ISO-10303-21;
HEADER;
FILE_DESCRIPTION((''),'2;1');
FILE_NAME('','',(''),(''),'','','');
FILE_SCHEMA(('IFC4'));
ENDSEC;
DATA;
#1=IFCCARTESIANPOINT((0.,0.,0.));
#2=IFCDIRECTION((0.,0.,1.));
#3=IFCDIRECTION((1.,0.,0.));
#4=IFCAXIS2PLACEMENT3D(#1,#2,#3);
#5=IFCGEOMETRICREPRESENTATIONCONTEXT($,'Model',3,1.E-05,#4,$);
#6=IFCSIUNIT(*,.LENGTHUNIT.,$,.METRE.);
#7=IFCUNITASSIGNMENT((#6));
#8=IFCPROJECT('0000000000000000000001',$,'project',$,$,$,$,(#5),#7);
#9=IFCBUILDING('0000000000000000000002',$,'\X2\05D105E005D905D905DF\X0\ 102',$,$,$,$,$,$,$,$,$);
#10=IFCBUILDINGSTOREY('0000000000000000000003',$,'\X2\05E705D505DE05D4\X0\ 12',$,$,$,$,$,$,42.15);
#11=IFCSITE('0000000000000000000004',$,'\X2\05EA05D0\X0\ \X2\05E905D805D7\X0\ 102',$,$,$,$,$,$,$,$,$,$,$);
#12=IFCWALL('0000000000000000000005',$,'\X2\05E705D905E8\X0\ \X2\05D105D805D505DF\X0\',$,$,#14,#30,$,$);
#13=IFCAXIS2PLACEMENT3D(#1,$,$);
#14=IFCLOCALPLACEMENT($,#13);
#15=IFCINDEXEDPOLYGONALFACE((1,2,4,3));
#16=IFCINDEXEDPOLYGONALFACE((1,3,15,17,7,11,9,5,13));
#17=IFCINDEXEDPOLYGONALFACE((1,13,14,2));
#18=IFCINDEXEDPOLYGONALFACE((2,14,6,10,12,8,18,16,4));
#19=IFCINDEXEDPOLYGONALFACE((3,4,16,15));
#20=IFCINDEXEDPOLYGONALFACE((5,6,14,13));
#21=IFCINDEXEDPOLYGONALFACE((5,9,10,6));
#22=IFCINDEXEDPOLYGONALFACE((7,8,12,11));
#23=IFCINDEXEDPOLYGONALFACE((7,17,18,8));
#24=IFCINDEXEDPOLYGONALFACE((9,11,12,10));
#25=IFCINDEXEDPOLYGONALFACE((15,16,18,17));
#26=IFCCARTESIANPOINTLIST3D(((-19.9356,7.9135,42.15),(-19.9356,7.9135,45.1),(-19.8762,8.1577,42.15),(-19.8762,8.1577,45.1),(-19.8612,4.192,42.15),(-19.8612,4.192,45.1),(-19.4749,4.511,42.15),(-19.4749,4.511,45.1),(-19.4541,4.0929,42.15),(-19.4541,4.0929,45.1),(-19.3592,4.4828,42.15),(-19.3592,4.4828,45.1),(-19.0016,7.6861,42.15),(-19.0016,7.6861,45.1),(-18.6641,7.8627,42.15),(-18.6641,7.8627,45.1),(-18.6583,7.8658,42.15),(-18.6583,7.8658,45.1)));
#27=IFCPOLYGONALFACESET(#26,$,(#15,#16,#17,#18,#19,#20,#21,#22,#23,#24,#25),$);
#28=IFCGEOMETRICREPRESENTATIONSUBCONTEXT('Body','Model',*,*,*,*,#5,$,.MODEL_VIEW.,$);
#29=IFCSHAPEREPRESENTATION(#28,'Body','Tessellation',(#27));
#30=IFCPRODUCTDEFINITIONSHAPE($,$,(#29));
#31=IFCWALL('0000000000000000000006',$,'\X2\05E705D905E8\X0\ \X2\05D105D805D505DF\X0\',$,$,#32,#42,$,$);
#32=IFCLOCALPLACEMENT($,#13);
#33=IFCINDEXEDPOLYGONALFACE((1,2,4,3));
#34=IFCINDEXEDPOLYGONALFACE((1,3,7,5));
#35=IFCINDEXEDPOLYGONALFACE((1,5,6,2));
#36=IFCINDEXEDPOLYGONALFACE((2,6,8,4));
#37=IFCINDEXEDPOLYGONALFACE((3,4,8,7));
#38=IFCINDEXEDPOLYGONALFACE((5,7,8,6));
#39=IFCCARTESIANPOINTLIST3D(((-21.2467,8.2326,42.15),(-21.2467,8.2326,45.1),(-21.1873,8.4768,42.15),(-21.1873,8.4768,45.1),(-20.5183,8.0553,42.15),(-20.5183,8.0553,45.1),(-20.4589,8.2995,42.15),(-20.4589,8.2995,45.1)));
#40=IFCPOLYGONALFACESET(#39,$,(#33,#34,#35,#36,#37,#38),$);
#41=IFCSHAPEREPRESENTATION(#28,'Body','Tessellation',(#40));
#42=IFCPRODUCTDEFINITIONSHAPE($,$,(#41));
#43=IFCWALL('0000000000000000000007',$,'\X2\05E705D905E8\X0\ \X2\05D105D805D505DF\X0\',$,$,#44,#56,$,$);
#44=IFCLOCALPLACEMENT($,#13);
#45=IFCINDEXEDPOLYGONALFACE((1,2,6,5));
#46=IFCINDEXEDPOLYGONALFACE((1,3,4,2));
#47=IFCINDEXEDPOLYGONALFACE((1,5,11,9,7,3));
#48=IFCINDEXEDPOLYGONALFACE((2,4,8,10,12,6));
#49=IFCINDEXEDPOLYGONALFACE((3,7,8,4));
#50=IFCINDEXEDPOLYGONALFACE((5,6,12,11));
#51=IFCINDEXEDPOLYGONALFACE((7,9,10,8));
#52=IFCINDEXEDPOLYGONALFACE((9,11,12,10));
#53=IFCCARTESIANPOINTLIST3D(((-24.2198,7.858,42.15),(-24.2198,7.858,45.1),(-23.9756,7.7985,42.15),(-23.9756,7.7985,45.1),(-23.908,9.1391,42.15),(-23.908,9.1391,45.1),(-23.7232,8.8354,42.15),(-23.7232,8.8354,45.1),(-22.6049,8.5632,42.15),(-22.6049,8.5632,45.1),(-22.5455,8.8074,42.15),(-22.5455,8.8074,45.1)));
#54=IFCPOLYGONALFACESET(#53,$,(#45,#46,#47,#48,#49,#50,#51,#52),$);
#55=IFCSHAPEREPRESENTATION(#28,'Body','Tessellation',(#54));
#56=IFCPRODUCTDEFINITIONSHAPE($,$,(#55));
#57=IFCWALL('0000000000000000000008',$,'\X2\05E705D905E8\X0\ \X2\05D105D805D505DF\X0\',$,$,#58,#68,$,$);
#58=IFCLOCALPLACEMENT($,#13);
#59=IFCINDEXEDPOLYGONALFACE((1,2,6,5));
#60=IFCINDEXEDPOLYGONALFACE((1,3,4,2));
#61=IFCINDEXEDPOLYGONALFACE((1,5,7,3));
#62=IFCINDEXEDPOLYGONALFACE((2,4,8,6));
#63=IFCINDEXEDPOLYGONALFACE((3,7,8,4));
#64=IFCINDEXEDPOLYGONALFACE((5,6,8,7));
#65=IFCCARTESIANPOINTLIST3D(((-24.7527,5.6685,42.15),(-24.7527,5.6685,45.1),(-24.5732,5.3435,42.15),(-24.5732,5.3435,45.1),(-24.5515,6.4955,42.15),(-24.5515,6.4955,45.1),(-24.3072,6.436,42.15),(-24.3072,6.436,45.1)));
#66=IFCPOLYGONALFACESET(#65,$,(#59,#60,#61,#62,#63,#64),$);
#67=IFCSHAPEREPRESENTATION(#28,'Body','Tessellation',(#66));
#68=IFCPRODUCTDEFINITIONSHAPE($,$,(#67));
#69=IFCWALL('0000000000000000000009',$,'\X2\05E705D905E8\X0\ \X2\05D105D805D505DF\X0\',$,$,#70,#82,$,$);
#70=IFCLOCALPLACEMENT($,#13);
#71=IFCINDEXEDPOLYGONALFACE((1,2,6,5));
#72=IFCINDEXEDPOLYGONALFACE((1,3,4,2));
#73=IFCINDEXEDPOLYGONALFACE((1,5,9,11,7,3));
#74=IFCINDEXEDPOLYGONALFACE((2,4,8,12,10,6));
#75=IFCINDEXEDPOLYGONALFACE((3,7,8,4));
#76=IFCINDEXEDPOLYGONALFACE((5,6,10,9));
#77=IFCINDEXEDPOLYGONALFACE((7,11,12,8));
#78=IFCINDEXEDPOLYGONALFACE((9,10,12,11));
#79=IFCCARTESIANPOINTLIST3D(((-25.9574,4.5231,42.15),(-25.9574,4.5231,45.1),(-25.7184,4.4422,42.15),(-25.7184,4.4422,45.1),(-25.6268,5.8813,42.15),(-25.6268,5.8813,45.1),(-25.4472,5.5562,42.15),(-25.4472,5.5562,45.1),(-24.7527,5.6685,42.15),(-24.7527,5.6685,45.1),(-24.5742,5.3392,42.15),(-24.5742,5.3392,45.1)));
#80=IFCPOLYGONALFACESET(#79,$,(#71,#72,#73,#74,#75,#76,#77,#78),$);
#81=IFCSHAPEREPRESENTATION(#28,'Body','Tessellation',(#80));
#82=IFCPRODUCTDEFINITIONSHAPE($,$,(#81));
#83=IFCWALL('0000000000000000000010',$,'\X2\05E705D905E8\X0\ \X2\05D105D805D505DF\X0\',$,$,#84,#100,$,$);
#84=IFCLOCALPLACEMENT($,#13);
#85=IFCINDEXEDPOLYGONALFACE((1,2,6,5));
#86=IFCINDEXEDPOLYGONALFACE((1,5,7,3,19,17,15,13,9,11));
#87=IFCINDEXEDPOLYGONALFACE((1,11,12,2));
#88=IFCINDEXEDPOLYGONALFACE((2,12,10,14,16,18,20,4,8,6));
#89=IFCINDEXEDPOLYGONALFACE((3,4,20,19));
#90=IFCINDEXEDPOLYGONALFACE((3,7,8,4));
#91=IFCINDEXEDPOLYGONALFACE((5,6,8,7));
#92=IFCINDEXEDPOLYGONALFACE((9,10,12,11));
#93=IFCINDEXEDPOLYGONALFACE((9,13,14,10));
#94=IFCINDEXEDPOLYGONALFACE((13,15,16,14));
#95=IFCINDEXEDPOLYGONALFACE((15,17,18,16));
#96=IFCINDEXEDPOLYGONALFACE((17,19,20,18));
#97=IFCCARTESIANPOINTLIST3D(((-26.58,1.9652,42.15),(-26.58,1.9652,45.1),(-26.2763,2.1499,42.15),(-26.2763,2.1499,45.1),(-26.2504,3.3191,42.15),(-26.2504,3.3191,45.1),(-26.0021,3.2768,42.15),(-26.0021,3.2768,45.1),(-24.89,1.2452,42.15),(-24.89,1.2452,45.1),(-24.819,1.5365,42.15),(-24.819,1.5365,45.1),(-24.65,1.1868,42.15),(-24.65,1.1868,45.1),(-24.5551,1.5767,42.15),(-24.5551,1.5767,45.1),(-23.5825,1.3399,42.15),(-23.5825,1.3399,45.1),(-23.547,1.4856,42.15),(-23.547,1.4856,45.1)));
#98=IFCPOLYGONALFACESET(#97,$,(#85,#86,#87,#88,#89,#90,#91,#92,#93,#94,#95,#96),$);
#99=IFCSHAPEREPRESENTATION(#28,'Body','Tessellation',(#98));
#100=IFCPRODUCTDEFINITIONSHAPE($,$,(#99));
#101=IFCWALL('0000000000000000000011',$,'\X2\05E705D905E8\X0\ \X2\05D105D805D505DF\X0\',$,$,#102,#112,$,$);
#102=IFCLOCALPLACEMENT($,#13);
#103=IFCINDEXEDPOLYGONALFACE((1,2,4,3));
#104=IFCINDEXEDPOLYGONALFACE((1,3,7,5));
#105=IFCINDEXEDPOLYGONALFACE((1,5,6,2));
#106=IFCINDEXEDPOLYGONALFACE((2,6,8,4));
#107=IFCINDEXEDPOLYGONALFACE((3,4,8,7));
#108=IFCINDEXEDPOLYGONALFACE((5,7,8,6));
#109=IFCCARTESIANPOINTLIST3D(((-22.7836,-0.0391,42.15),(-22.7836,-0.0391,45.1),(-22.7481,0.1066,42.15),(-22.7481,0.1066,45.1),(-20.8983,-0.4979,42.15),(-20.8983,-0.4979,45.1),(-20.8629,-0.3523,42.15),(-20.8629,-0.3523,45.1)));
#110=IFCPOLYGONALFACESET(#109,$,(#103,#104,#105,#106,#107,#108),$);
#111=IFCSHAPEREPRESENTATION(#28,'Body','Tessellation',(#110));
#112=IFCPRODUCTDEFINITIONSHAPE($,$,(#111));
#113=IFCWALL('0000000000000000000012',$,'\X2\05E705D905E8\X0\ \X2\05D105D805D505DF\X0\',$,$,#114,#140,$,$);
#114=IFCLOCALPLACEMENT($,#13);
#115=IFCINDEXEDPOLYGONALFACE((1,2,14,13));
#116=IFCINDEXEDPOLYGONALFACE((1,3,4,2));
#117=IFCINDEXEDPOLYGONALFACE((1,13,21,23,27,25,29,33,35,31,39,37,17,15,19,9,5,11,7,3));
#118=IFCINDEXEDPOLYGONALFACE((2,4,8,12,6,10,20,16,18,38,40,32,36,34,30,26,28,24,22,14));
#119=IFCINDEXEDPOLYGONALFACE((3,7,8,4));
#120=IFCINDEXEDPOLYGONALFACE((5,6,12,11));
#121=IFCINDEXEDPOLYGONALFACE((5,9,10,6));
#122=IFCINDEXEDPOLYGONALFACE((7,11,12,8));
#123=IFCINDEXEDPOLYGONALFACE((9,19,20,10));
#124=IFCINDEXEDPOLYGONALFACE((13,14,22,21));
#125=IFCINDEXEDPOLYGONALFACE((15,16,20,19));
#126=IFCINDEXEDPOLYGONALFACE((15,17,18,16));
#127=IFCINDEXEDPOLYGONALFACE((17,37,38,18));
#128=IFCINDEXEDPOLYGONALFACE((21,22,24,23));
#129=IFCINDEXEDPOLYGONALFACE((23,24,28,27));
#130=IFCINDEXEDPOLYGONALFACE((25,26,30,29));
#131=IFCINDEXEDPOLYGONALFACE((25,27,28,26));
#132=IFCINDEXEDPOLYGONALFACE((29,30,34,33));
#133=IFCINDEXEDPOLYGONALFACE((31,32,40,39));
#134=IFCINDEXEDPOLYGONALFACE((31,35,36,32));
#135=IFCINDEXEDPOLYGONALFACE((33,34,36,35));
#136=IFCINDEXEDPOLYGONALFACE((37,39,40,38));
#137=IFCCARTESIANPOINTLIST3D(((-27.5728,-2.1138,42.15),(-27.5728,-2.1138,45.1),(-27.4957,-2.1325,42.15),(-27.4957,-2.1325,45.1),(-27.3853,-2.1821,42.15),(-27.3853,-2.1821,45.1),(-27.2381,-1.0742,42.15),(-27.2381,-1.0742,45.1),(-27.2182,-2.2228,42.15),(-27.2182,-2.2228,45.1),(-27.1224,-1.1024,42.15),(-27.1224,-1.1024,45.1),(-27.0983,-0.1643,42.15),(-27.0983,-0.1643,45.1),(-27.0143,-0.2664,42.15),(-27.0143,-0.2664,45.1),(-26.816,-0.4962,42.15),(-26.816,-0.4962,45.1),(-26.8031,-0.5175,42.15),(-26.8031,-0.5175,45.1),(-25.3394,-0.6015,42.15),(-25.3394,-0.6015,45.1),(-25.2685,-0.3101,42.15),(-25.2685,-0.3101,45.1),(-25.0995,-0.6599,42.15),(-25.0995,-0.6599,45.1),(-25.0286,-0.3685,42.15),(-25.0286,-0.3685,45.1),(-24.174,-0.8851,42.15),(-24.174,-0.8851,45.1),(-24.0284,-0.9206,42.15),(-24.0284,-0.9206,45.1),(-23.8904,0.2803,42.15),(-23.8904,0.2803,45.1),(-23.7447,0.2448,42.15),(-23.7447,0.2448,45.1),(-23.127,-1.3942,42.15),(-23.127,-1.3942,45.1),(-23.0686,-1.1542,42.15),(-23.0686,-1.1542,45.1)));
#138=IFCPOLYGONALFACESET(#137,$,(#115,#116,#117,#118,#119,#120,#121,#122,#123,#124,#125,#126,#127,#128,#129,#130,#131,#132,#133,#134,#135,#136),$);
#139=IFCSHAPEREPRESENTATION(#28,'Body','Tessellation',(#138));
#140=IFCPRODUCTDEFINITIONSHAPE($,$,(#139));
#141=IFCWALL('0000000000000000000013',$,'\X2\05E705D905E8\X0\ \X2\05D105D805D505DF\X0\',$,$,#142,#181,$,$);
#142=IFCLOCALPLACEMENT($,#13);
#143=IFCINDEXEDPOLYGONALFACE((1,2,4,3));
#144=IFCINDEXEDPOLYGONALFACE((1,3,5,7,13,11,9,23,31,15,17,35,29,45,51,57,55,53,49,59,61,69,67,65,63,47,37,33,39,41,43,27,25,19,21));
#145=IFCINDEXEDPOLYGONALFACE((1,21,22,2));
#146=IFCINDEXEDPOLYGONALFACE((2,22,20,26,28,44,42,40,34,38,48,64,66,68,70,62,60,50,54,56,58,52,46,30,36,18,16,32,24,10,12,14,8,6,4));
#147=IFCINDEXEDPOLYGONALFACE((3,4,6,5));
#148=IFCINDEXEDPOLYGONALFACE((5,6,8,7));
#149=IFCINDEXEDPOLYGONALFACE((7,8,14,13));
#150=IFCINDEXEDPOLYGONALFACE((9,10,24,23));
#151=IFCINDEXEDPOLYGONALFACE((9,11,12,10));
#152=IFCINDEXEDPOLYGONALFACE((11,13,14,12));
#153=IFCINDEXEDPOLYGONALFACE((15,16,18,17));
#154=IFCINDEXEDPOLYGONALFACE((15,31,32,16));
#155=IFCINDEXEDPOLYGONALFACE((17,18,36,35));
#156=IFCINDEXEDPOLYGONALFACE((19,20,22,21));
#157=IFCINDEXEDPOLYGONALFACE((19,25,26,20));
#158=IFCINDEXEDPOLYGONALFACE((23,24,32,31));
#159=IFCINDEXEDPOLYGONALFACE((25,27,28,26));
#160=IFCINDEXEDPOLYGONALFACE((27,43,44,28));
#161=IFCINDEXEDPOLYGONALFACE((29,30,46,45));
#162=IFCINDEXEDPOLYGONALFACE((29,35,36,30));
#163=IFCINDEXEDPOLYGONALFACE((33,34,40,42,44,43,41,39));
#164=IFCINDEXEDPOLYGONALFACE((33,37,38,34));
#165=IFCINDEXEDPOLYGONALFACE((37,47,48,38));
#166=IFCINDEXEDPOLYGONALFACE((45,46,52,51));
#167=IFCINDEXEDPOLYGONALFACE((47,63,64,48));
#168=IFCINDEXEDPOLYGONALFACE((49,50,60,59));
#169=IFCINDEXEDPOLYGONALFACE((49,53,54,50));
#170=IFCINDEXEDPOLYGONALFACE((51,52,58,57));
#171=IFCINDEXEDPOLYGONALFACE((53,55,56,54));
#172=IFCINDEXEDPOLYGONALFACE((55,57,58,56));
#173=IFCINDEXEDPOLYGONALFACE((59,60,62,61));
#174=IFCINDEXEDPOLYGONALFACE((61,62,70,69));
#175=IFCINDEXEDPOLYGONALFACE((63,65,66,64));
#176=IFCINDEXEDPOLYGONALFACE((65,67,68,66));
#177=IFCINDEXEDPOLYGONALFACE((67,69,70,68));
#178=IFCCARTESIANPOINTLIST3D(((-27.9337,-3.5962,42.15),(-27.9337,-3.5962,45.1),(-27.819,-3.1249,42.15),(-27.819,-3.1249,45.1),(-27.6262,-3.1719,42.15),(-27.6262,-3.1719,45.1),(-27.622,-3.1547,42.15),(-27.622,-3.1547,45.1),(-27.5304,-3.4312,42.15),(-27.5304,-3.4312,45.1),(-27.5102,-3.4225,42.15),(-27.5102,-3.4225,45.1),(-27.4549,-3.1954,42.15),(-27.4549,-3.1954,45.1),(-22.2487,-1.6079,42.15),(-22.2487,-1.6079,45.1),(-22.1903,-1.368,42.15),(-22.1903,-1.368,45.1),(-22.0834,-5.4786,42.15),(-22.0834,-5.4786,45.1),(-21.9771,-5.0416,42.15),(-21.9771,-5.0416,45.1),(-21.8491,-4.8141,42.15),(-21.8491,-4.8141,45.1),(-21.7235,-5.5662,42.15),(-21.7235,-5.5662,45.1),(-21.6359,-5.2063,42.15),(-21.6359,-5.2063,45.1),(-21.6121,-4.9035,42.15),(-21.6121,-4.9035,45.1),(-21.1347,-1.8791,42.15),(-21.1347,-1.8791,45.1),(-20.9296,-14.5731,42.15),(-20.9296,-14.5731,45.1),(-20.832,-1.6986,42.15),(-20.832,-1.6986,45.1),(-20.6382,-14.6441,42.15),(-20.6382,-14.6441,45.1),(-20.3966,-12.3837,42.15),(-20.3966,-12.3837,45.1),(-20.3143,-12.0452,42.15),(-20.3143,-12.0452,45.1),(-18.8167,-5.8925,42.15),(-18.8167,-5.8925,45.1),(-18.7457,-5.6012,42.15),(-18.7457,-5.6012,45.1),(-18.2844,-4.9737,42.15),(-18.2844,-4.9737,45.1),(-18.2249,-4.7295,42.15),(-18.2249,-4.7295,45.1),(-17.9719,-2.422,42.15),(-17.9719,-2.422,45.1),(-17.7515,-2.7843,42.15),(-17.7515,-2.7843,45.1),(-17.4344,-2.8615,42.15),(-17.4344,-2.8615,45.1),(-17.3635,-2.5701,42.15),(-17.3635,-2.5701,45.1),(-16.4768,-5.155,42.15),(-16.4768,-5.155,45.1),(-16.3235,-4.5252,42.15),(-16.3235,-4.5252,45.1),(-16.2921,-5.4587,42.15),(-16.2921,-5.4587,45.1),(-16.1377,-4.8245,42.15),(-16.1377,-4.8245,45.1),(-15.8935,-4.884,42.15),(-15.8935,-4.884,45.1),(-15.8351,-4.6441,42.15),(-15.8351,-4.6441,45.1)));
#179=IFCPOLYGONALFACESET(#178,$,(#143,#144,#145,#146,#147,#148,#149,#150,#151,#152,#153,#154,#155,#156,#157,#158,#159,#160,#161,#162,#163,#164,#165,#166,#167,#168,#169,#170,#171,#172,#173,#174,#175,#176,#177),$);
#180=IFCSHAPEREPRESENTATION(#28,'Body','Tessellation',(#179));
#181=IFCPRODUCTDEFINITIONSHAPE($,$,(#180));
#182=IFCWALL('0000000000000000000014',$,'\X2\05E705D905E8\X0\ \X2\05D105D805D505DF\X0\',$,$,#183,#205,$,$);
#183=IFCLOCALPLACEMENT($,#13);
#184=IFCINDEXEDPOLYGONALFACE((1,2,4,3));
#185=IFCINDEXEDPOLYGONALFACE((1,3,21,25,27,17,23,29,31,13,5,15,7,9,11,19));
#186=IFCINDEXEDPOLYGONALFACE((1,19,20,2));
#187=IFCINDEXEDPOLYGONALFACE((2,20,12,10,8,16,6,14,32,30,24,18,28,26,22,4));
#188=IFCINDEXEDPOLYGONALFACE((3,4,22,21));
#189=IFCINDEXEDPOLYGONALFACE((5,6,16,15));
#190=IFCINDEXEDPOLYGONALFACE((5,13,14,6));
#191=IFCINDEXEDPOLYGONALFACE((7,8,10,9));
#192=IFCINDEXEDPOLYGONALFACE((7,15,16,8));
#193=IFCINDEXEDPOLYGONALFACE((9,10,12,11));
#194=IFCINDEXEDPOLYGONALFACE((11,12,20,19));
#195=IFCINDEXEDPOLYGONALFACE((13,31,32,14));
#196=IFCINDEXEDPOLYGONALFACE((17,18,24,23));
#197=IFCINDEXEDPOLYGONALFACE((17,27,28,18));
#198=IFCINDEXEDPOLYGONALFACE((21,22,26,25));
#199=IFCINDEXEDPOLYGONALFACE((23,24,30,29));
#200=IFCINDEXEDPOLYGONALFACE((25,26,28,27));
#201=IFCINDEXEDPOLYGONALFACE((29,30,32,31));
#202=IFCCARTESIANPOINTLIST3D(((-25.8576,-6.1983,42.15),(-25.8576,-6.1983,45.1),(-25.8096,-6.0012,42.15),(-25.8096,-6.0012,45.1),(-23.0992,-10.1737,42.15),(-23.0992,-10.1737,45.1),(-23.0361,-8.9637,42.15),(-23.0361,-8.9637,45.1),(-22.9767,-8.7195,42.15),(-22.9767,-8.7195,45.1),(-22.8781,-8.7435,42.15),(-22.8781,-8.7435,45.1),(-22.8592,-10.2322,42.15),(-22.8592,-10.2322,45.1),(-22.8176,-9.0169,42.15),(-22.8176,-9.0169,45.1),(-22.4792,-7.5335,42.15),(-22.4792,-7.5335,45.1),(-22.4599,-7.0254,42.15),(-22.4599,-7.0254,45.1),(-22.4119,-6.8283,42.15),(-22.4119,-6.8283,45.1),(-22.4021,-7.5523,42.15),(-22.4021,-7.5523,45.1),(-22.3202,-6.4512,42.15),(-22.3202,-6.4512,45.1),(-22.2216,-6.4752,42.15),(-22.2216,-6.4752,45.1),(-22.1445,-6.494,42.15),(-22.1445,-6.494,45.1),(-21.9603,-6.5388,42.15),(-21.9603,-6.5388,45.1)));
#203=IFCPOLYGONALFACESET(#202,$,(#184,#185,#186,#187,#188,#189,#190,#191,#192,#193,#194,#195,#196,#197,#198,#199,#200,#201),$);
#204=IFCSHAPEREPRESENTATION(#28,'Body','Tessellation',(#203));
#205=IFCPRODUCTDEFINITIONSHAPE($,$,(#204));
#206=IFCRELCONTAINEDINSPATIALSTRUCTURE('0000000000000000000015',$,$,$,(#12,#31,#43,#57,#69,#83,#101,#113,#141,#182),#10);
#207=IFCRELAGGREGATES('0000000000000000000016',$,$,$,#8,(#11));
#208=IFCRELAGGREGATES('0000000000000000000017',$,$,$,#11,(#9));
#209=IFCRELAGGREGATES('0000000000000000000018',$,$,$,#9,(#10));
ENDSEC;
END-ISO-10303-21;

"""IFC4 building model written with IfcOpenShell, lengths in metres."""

from ifc_helpers import new_model, si_unit, frame, origin_with_axes, context, subcontext, project, spatial, polyline, outline, extrude, element, save


model = new_model("IFC4")

# Units and contexts
model_context = context("Model", 3, precision=1e-05, world=origin_with_axes())
body_context = subcontext(model_context, "Body", "Model", "MODEL_VIEW")
ifc_project = project(units=[si_unit("LENGTHUNIT", "METRE")], contexts=[model_context])

# Site, building, storey
site = spatial("IfcSite", under=ifc_project, Name="תא שטח 102")
building = spatial("IfcBuilding", under=site, Name="בניין 102")
storey = spatial("IfcBuildingStorey", under=building, Name="קומה 12", Elevation=42.15)

# Walls
element("IfcWall", 1, inside=storey, Name="קיר בטון", context=body_context, shape_type="SweptSolid", body=[
    extrude(outline(polyline([(-19.0016, 7.6861), (-19.8612, 4.192), (-19.4541, 4.0929), (-19.3592, 4.4828), (-19.4749, 4.511), (-18.6583, 7.8658), (-18.7159, 7.8344), (-18.6636, 7.8626), (-19.8762, 8.1577), (-19.9356, 7.9135), (-19.0016, 7.6861)])), frame((0.0, 0.0, 42.15)), (0.0, 0.0, 1.0), 2.95),
])
element("IfcWall", 2, inside=storey, Name="קיר בטון", context=body_context, shape_type="SweptSolid", body=[
    extrude(outline(polyline([(-20.4589, 8.2995), (-21.1873, 8.4768), (-21.2467, 8.2326), (-20.5183, 8.0553), (-20.4589, 8.2995)])), frame((0.0, 0.0, 42.15)), (0.0, 0.0, 1.0), 2.95),
])
element("IfcWall", 3, inside=storey, Name="קיר בטון", context=body_context, shape_type="SweptSolid", body=[
    extrude(outline(polyline([(-24.2198, 7.858), (-23.9756, 7.7985), (-23.7232, 8.8354), (-22.6049, 8.5632), (-22.5455, 8.8074), (-23.908, 9.1391), (-24.2198, 7.858)])), frame((0.0, 0.0, 42.15)), (0.0, 0.0, 1.0), 2.95),
])
element("IfcWall", 4, inside=storey, Name="קיר בטון", context=body_context, shape_type="SweptSolid", body=[
    extrude(outline(polyline([(-24.7527, 5.6685), (-24.5732, 5.3435), (-24.3072, 6.436), (-24.5515, 6.4955), (-24.7527, 5.6685)])), frame((0.0, 0.0, 42.15)), (0.0, 0.0, 1.0), 2.95),
])
element("IfcWall", 5, inside=storey, Name="קיר בטון", context=body_context, shape_type="SweptSolid", body=[
    extrude(outline(polyline([(-25.9574, 4.5231), (-25.7184, 4.4422), (-25.4472, 5.5562), (-24.5742, 5.3392), (-24.7527, 5.6685), (-25.6268, 5.8813), (-25.9574, 4.5231)])), frame((0.0, 0.0, 42.15)), (0.0, 0.0, 1.0), 2.95),
])
element("IfcWall", 6, inside=storey, Name="קיר בטון", context=body_context, shape_type="SweptSolid", body=[
    extrude(outline(polyline([(-26.58, 1.9652), (-24.819, 1.5365), (-24.89, 1.2452), (-24.65, 1.1868), (-24.5551, 1.5767), (-23.5825, 1.3399), (-23.547, 1.4856), (-26.2763, 2.1499), (-26.0021, 3.2768), (-26.2504, 3.3191), (-26.58, 1.9652)])), frame((0.0, 0.0, 42.15)), (0.0, 0.0, 1.0), 2.95),
])
element("IfcWall", 7, inside=storey, Name="קיר בטון", context=body_context, shape_type="SweptSolid", body=[
    extrude(outline(polyline([(-22.7836, -0.0391), (-20.8983, -0.4979), (-20.8629, -0.3523), (-22.7481, 0.1066), (-22.7836, -0.0391)])), frame((0.0, 0.0, 42.15)), (0.0, 0.0, 1.0), 2.95),
])
element("IfcWall", 8, inside=storey, Name="קיר בטון", context=body_context, shape_type="SweptSolid", body=[
    extrude(outline(polyline([(-25.3394, -0.6015), (-27.0983, -0.1643), (-27.5728, -2.1138), (-27.4957, -2.1325), (-27.2381, -1.0742), (-27.1224, -1.1024), (-27.3853, -2.1821), (-27.2182, -2.2228), (-26.8031, -0.5175), (-27.0143, -0.2664), (-26.816, -0.4962), (-23.127, -1.3942), (-23.0686, -1.1542), (-24.0284, -0.9206), (-23.7447, 0.2448), (-23.8904, 0.2803), (-24.174, -0.8851), (-25.0995, -0.6599), (-25.0286, -0.3685), (-25.2685, -0.3101), (-25.3394, -0.6015)])), frame((0.0, 0.0, 42.15)), (0.0, 0.0, 1.0), 2.95),
])
element("IfcWall", 9, inside=storey, Name="קיר בטון", context=body_context, shape_type="SweptSolid", body=[
    extrude(outline(polyline([(-21.8491, -4.8141), (-27.5304, -3.4312), (-27.5102, -3.4225), (-27.4549, -3.1954), (-27.622, -3.1547), (-27.6262, -3.1719), (-27.819, -3.1249), (-27.9337, -3.5962), (-21.9771, -5.0416), (-22.0834, -5.4786), (-21.7235, -5.5662), (-21.6359, -5.2063), (-18.8167, -5.8925), (-20.3143, -12.0452), (-20.3966, -12.3837), (-20.9296, -14.5731), (-20.6382, -14.6441), (-18.2844, -4.9737), (-16.2921, -5.4587), (-16.1377, -4.8245), (-15.8935, -4.884), (-15.8351, -4.6441), (-16.3235, -4.5252), (-16.4768, -5.155), (-18.2249, -4.7295), (-17.7515, -2.7843), (-17.4344, -2.8615), (-17.3635, -2.5701), (-17.9719, -2.422), (-18.7457, -5.6012), (-21.6121, -4.9035), (-20.832, -1.6986), (-22.1903, -1.368), (-22.2487, -1.6079), (-21.1347, -1.8791), (-21.8491, -4.8141)])), frame((0.0, 0.0, 42.15)), (0.0, 0.0, 1.0), 2.95),
])
element("IfcWall", 10, inside=storey, Name="קיר בטון", context=body_context, shape_type="SweptSolid", body=[
    extrude(outline(polyline([(-25.8576, -6.1983), (-22.4599, -7.0254), (-22.8781, -8.7435), (-22.9767, -8.7195), (-23.0361, -8.9637), (-22.8176, -9.0169), (-23.0992, -10.1737), (-22.8592, -10.2322), (-21.9603, -6.5388), (-22.1445, -6.494), (-22.4021, -7.5523), (-22.4792, -7.5335), (-22.2216, -6.4752), (-22.3202, -6.4512), (-22.4119, -6.8283), (-25.8096, -6.0012), (-25.8576, -6.1983)])), frame((0.0, 0.0, 42.15)), (0.0, 0.0, 1.0), 2.95),
])

save(model, "model.ifc")
